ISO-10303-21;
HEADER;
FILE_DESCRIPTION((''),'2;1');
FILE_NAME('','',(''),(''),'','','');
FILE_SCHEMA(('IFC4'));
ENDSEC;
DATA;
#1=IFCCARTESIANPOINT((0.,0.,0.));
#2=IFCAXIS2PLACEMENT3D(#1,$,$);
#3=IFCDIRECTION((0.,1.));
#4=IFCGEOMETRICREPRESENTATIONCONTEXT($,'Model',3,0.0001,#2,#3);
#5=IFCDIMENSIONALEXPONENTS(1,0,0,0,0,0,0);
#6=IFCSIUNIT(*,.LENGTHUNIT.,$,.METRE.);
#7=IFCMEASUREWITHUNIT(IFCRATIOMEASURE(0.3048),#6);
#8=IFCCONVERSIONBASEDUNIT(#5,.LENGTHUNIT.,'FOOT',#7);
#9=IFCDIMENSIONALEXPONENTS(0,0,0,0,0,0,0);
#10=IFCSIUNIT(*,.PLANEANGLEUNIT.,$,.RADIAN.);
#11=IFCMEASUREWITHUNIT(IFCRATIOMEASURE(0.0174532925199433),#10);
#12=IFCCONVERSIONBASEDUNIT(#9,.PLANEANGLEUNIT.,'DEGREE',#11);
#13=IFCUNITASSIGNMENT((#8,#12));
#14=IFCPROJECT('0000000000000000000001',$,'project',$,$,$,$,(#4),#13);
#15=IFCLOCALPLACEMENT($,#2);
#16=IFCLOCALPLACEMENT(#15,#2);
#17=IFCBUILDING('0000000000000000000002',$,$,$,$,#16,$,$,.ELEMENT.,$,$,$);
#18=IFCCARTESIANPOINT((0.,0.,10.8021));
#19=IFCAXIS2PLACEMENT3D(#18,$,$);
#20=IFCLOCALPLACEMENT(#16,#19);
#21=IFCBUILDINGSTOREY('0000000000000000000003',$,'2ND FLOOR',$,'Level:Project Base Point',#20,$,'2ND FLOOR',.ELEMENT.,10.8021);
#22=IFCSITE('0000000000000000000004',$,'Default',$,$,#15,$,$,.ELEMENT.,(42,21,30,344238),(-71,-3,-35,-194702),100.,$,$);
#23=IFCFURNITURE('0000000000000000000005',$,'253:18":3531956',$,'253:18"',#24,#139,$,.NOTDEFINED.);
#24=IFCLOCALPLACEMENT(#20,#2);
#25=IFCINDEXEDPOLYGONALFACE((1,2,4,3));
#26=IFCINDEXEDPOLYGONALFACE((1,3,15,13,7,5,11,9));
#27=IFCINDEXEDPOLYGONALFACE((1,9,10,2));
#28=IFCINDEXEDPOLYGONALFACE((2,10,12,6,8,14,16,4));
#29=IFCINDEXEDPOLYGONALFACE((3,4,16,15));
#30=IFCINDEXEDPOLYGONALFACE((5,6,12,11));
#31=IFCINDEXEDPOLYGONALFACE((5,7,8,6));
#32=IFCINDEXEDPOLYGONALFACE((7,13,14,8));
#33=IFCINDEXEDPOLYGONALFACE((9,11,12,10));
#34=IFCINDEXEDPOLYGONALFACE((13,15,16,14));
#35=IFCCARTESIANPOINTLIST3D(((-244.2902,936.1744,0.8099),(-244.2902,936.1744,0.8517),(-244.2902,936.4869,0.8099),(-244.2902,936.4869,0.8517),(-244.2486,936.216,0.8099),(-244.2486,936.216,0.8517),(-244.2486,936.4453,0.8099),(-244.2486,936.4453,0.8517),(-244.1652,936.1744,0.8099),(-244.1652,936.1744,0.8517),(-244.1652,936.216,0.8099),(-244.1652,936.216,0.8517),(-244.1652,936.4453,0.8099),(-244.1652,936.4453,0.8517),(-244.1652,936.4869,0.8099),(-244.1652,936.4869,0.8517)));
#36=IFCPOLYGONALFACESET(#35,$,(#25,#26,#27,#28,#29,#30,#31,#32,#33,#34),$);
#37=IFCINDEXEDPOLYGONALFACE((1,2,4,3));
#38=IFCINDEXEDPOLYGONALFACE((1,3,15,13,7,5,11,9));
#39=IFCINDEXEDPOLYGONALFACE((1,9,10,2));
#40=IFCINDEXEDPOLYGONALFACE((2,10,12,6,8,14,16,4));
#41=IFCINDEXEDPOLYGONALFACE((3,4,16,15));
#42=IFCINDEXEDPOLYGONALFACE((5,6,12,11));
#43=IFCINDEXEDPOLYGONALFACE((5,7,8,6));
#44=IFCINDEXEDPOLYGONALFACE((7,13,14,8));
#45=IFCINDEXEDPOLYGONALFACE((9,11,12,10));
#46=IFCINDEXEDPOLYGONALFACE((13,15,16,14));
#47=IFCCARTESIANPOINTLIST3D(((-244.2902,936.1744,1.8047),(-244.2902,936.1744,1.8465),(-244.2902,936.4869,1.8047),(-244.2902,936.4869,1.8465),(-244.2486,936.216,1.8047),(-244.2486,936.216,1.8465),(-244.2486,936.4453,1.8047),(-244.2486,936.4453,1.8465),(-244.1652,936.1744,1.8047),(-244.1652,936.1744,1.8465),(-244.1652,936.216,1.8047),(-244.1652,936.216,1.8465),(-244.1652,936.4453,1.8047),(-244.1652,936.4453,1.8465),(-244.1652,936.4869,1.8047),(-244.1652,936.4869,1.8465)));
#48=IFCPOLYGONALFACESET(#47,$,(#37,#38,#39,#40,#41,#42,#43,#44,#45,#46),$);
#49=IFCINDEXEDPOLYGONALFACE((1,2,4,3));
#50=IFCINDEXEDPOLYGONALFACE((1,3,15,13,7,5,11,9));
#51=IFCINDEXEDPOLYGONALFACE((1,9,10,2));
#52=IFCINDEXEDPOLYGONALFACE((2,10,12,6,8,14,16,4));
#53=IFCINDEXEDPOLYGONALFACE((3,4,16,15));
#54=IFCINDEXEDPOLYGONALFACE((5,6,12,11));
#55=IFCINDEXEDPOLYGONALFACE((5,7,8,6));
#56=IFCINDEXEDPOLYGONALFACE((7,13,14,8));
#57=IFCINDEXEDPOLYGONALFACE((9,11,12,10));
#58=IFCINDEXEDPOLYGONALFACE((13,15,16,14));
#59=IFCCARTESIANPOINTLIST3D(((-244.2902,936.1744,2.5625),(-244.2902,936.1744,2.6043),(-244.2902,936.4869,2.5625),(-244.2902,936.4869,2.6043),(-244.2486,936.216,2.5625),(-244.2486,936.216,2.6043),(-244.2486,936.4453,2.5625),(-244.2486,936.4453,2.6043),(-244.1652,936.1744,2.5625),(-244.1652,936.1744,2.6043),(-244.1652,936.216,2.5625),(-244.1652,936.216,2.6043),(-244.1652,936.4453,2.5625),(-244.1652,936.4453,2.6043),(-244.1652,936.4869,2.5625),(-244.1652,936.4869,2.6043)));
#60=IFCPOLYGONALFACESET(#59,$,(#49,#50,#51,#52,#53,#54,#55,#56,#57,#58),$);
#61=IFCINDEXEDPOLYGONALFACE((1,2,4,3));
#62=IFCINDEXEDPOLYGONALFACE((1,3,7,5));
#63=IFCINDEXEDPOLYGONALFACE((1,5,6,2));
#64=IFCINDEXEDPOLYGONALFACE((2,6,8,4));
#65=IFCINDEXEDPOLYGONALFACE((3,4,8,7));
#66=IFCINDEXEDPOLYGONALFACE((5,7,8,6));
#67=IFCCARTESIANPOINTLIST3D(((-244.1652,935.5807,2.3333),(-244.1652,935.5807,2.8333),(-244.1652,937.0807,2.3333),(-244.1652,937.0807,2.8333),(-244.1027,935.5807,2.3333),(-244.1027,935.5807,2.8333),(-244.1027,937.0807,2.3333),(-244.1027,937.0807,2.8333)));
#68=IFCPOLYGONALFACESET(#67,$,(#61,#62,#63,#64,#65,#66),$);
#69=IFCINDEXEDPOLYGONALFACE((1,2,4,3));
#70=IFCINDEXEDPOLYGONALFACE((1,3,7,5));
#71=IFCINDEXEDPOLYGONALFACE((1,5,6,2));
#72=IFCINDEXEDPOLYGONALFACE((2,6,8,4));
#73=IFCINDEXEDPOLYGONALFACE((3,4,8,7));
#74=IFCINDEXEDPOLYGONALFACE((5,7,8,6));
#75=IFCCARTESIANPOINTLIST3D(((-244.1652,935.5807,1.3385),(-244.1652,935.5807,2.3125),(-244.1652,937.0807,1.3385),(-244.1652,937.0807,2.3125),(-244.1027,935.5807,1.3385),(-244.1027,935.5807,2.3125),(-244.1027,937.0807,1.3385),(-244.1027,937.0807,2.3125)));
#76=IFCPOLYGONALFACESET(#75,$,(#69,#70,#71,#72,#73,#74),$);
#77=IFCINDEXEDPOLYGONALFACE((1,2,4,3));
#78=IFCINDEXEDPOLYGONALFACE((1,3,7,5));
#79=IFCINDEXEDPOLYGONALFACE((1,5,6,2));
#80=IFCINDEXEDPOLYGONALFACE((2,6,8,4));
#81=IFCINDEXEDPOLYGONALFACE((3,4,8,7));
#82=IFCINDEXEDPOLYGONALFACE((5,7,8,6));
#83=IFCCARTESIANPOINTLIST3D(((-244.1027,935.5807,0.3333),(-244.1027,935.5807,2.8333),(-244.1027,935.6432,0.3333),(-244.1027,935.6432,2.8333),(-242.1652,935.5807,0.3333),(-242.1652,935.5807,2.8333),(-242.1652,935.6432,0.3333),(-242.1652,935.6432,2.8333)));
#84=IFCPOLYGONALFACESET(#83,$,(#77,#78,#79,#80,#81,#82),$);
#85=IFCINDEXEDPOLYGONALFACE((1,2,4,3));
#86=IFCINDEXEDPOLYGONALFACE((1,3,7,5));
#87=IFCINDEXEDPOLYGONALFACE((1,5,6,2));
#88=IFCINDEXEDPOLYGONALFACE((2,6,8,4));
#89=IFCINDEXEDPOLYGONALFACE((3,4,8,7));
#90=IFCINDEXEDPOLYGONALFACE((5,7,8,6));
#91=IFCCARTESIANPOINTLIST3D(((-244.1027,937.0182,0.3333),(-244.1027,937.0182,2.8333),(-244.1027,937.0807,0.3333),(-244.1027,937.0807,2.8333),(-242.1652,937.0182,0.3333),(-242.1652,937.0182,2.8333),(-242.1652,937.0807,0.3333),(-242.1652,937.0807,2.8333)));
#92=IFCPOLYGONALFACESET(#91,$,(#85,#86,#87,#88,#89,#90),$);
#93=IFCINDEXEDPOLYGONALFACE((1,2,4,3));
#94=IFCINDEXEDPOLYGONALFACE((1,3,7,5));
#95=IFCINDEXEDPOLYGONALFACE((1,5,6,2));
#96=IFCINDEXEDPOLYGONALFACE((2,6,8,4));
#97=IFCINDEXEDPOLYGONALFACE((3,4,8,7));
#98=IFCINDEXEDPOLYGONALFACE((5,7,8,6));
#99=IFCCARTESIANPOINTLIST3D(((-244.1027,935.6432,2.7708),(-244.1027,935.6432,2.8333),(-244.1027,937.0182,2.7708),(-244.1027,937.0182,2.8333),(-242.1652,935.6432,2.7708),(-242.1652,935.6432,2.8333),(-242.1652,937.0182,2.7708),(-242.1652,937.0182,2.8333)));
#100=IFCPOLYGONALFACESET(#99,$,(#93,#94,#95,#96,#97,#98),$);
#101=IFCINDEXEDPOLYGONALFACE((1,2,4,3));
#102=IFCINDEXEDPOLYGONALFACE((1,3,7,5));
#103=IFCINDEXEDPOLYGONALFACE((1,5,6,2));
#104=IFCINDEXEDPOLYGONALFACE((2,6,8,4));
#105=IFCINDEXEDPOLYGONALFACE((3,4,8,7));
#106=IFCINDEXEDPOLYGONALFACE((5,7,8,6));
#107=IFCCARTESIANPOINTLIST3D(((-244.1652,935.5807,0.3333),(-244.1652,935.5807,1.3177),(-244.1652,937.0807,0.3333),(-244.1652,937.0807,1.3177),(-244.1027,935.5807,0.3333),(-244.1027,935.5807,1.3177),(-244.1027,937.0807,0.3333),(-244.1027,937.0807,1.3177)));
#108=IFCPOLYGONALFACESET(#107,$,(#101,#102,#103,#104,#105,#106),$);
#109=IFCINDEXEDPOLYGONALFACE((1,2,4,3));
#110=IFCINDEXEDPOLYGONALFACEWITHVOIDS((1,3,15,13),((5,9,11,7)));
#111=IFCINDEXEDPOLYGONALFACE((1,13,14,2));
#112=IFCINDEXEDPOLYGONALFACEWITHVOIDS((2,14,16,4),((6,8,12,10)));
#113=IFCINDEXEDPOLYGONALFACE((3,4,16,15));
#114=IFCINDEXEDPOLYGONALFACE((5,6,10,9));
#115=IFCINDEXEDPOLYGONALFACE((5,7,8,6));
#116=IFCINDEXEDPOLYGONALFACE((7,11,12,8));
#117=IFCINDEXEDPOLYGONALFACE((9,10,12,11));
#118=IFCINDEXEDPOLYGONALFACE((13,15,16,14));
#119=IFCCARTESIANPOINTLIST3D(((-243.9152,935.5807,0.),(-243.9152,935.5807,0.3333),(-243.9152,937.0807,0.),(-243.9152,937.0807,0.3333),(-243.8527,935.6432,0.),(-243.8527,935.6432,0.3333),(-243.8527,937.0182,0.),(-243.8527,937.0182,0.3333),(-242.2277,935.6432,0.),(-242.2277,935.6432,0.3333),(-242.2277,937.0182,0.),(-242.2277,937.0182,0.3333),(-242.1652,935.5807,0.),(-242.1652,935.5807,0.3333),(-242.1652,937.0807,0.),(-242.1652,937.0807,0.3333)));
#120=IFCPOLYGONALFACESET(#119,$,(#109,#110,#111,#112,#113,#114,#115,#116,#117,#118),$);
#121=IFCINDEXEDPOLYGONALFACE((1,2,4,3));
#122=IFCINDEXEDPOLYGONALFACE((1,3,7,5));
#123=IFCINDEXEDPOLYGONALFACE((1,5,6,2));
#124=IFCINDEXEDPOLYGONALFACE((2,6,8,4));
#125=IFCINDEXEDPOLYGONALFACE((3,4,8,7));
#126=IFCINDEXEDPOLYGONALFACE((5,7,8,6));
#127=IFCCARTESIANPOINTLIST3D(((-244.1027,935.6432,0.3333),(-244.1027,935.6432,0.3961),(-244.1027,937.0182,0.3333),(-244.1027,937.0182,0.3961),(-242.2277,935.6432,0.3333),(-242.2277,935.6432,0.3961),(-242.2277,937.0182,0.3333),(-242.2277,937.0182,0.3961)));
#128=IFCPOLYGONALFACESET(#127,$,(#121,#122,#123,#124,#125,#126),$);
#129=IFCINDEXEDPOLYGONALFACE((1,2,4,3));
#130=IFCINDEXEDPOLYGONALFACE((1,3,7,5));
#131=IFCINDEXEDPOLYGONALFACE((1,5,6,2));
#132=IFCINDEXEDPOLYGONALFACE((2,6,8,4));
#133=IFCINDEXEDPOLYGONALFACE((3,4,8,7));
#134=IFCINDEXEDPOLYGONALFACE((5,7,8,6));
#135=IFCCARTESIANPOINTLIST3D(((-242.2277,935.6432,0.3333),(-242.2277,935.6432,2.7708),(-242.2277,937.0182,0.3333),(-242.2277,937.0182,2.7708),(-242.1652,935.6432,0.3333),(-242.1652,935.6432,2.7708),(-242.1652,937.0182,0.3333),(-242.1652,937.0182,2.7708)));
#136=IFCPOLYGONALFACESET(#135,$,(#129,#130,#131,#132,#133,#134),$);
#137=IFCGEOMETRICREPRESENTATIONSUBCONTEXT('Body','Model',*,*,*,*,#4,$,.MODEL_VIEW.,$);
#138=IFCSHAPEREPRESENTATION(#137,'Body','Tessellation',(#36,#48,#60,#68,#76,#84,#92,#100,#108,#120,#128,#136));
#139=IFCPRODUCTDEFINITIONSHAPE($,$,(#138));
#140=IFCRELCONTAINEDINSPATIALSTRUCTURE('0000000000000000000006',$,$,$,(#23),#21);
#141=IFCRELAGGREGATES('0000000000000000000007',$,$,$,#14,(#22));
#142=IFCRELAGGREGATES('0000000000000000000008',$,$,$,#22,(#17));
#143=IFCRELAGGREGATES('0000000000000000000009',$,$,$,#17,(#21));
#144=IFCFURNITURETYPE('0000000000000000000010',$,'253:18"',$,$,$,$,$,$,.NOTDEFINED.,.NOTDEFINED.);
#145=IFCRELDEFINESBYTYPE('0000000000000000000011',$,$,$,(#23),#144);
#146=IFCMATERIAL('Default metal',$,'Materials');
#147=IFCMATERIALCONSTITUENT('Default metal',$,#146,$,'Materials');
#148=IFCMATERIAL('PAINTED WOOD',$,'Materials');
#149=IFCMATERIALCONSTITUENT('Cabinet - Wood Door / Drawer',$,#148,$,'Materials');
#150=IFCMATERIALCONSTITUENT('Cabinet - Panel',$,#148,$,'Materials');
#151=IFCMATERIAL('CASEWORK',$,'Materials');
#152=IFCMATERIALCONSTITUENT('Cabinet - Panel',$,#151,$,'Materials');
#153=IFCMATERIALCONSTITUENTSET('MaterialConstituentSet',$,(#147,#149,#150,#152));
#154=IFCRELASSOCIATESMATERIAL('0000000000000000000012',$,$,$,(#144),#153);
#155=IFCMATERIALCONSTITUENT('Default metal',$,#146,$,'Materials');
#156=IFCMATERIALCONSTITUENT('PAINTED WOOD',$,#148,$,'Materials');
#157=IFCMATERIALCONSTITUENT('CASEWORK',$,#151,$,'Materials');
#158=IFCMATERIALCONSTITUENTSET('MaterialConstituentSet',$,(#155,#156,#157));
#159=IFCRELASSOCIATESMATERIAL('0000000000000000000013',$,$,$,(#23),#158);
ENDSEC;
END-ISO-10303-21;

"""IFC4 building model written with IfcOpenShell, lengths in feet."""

from ifc_helpers import new_model, entity, si_unit, converted_unit, direction, frame, frame_2d, origin, origin_2d_with_axis, place, context, subcontext, project, spatial, polyline, rectangle, outline, extrude, source, transform, mapped, material, constituent, constituent_set, type_object, type_shapes, element, save


model = new_model("IFC4")

# Units and contexts
model_context = context("Model", 3, precision=0.0001, world=origin(), true_north=direction((0.0, 1.0)))
body_context = subcontext(model_context, "Body", "Model", "MODEL_VIEW")
ifc_project = project(units=[converted_unit("LENGTHUNIT", "FOOT", entity("IfcRatioMeasure", 0.3048), si_unit("LENGTHUNIT", "METRE"), dimensions=[1, 0, 0, 0, 0, 0, 0]), converted_unit("PLANEANGLEUNIT", "DEGREE", entity("IfcRatioMeasure", 0.0174532925199433), si_unit("PLANEANGLEUNIT", "RADIAN"), dimensions=[0, 0, 0, 0, 0, 0, 0])], contexts=[model_context])

# Site, building, storey
site_placement = place(None, origin())
site = spatial("IfcSite", under=ifc_project, at=site_placement, Name="Default", CompositionType="ELEMENT", RefLatitude=(42, 21, 30, 344238), RefLongitude=(-71, -3, -35, -194702), RefElevation=100.0)
building_placement = place(site_placement, origin())
building = spatial("IfcBuilding", under=site, at=building_placement, CompositionType="ELEMENT")
storey_placement = place(building_placement, frame((0.0, 0.0, 10.8021)))
storey = spatial("IfcBuildingStorey", under=building, at=storey_placement, Name="2ND FLOOR", ObjectType="Level:Project Base Point", LongName="2ND FLOOR", CompositionType="ELEMENT", Elevation=10.8021)

# Shared definitions
ifc_material_1 = material(Name="Default metal", Category="Materials")
ifc_material_2 = material(Name="PAINTED WOOD", Category="Materials")
ifc_material_3 = material(Name="CASEWORK", Category="Materials")

# Furniture
ifc_constituent_1 = constituent(ifc_material_1, Name="Default metal", Category="Materials")
ifc_constituent_2 = constituent(ifc_material_2, Name="PAINTED WOOD", Category="Materials")
ifc_constituent_3 = constituent(ifc_material_3, Name="CASEWORK", Category="Materials")
ifc_constituent_set_1 = constituent_set(constituents=[ifc_constituent_1, ifc_constituent_2, ifc_constituent_3], Name="MaterialConstituentSet")
ifc_constituent_4 = constituent(ifc_material_1, Name="Default metal", Category="Materials")
ifc_constituent_5 = constituent(ifc_material_2, Name="Cabinet - Wood Door / Drawer", Category="Materials")
ifc_constituent_6 = constituent(ifc_material_2, Name="Cabinet - Panel", Category="Materials")
ifc_constituent_7 = constituent(ifc_material_3, Name="Cabinet - Panel", Category="Materials")
ifc_constituent_set_2 = constituent_set(constituents=[ifc_constituent_4, ifc_constituent_5, ifc_constituent_6, ifc_constituent_7], Name="MaterialConstituentSet")
furniture_type_1 = type_object("IfcFurnitureType", Name="253:18\"", AssemblyPlace="NOTDEFINED", PredefinedType="NOTDEFINED", material=ifc_constituent_set_2)
shared_shape_1 = source(origin(), body_context, "Body", "SweptSolid", [
    extrude(outline(polyline([(-0.1562, -0.0521), (-0.1146, -0.0521), (-0.1146, 0.0313), (0.1146, 0.0313), (0.1146, -0.0521), (0.1562, -0.0521), (0.1562, 0.0729), (-0.1562, 0.0729), (-0.1562, -0.0521)])), frame((0.0615, 2.0521, 0.8099)), (0.0, 0.0, 1.0), 0.0418),
    extrude(outline(polyline([(-0.1562, -0.0521), (-0.1146, -0.0521), (-0.1146, 0.0313), (0.1146, 0.0313), (0.1146, -0.0521), (0.1562, -0.0521), (0.1562, 0.0729), (-0.1562, 0.0729), (-0.1562, -0.0521)])), frame((0.0615, 2.0521, 1.8047)), (0.0, 0.0, 1.0), 0.0418),
    extrude(outline(polyline([(-0.1562, -0.0521), (-0.1146, -0.0521), (-0.1146, 0.0313), (0.1146, 0.0313), (0.1146, -0.0521), (0.1562, -0.0521), (0.1562, 0.0729), (-0.1562, 0.0729), (-0.1562, -0.0521)])), frame((0.0615, 2.0521, 2.5625)), (0.0, 0.0, 1.0), 0.0418),
    extrude(rectangle(XDim=1.5, YDim=0.0625, at=frame_2d((0.0, 0.0), x_axis=(1.0, 0.0))), frame((0.0615, 1.9688, 2.3333), z_axis=(0.0, 0.0, 1.0), x_axis=(-1.0, 0.0, 0.0)), (0.0, 0.0, 1.0), 0.5),
    extrude(rectangle(XDim=1.5, YDim=0.0625, at=frame_2d((0.0, 0.0), x_axis=(1.0, 0.0))), frame((0.0615, 1.9688, 1.3385), z_axis=(0.0, 0.0, 1.0), x_axis=(-1.0, 0.0, 0.0)), (0.0, 0.0, 1.0), 0.974),
    extrude(rectangle(XDim=1.9375, YDim=0.0625, at=frame_2d((0.0, 0.0), x_axis=(1.0, 0.0))), frame((-0.6573, 0.9687, 0.3333), z_axis=(0.0, 0.0, 1.0), x_axis=(0.0, -1.0, 0.0)), (0.0, 0.0, 1.0), 2.5),
    extrude(rectangle(XDim=1.9375, YDim=0.0625, at=frame_2d((0.0, 0.0), x_axis=(1.0, 0.0))), frame((0.7802, 0.9687, 0.3333), z_axis=(0.0, 0.0, 1.0), x_axis=(0.0, -1.0, 0.0)), (0.0, 0.0, 1.0), 2.5),
    extrude(rectangle(XDim=1.9375, YDim=1.375, at=origin_2d_with_axis()), frame((0.0615, 0.9688, 2.7708), z_axis=(0.0, 0.0, 1.0), x_axis=(0.0, 1.0, 0.0)), (0.0, 0.0, 1.0), 0.0625),
    extrude(rectangle(XDim=1.5, YDim=0.0625, at=frame_2d((0.0, 0.0), x_axis=(1.0, 0.0))), frame((0.0615, 1.9688, 0.3333), z_axis=(0.0, 0.0, 1.0), x_axis=(-1.0, 0.0, 0.0)), (0.0, 0.0, 1.0), 0.9844),
    extrude(outline(polyline([(-0.875, -0.75), (0.875, -0.75), (0.875, 0.75), (-0.875, 0.75), (-0.875, -0.75)]), holes=[polyline([(-0.8125, -0.6875), (-0.8125, 0.6875), (0.8125, 0.6875), (0.8125, -0.6875), (-0.8125, -0.6875)])]), frame((0.0615, 0.875, 0.0), z_axis=(0.0, 0.0, 1.0), x_axis=(0.0, -1.0, 0.0)), (0.0, 0.0, 1.0), 0.3333),
    extrude(rectangle(XDim=1.875, YDim=1.375, at=origin_2d_with_axis()), frame((0.0615, 1.0, 0.3333), z_axis=(0.0, 0.0, 1.0), x_axis=(0.0, 1.0, 0.0)), (0.0, 0.0, 1.0), 0.0627),
    extrude(rectangle(XDim=1.375, YDim=0.0625, at=origin_2d_with_axis()), frame((0.0615, 0.0312, 0.3333), z_axis=(0.0, 0.0, 1.0), x_axis=(-1.0, 0.0, 0.0)), (0.0, 0.0, 1.0), 2.4375),
])
type_shapes(furniture_type_1, [shared_shape_1])
furniture_1_placement = place(storey_placement, frame((-242.1652, 936.2692, 0.0), z_axis=(0.0, 0.0, 1.0), x_axis=(0.0, 1.0, 0.0)))
element("IfcFurniture", 1, at=furniture_1_placement, inside=storey, type_object=furniture_type_1, material=ifc_constituent_set_1, Name="253:18\":3531956", ObjectType="253:18\"", PredefinedType="NOTDEFINED", context=body_context, shape_type="MappedRepresentation", body=[
    mapped(shared_shape_1, transform((0.0, 0.0, 0.0), scale=1.0)),
])

save(model, "model.ifc")
